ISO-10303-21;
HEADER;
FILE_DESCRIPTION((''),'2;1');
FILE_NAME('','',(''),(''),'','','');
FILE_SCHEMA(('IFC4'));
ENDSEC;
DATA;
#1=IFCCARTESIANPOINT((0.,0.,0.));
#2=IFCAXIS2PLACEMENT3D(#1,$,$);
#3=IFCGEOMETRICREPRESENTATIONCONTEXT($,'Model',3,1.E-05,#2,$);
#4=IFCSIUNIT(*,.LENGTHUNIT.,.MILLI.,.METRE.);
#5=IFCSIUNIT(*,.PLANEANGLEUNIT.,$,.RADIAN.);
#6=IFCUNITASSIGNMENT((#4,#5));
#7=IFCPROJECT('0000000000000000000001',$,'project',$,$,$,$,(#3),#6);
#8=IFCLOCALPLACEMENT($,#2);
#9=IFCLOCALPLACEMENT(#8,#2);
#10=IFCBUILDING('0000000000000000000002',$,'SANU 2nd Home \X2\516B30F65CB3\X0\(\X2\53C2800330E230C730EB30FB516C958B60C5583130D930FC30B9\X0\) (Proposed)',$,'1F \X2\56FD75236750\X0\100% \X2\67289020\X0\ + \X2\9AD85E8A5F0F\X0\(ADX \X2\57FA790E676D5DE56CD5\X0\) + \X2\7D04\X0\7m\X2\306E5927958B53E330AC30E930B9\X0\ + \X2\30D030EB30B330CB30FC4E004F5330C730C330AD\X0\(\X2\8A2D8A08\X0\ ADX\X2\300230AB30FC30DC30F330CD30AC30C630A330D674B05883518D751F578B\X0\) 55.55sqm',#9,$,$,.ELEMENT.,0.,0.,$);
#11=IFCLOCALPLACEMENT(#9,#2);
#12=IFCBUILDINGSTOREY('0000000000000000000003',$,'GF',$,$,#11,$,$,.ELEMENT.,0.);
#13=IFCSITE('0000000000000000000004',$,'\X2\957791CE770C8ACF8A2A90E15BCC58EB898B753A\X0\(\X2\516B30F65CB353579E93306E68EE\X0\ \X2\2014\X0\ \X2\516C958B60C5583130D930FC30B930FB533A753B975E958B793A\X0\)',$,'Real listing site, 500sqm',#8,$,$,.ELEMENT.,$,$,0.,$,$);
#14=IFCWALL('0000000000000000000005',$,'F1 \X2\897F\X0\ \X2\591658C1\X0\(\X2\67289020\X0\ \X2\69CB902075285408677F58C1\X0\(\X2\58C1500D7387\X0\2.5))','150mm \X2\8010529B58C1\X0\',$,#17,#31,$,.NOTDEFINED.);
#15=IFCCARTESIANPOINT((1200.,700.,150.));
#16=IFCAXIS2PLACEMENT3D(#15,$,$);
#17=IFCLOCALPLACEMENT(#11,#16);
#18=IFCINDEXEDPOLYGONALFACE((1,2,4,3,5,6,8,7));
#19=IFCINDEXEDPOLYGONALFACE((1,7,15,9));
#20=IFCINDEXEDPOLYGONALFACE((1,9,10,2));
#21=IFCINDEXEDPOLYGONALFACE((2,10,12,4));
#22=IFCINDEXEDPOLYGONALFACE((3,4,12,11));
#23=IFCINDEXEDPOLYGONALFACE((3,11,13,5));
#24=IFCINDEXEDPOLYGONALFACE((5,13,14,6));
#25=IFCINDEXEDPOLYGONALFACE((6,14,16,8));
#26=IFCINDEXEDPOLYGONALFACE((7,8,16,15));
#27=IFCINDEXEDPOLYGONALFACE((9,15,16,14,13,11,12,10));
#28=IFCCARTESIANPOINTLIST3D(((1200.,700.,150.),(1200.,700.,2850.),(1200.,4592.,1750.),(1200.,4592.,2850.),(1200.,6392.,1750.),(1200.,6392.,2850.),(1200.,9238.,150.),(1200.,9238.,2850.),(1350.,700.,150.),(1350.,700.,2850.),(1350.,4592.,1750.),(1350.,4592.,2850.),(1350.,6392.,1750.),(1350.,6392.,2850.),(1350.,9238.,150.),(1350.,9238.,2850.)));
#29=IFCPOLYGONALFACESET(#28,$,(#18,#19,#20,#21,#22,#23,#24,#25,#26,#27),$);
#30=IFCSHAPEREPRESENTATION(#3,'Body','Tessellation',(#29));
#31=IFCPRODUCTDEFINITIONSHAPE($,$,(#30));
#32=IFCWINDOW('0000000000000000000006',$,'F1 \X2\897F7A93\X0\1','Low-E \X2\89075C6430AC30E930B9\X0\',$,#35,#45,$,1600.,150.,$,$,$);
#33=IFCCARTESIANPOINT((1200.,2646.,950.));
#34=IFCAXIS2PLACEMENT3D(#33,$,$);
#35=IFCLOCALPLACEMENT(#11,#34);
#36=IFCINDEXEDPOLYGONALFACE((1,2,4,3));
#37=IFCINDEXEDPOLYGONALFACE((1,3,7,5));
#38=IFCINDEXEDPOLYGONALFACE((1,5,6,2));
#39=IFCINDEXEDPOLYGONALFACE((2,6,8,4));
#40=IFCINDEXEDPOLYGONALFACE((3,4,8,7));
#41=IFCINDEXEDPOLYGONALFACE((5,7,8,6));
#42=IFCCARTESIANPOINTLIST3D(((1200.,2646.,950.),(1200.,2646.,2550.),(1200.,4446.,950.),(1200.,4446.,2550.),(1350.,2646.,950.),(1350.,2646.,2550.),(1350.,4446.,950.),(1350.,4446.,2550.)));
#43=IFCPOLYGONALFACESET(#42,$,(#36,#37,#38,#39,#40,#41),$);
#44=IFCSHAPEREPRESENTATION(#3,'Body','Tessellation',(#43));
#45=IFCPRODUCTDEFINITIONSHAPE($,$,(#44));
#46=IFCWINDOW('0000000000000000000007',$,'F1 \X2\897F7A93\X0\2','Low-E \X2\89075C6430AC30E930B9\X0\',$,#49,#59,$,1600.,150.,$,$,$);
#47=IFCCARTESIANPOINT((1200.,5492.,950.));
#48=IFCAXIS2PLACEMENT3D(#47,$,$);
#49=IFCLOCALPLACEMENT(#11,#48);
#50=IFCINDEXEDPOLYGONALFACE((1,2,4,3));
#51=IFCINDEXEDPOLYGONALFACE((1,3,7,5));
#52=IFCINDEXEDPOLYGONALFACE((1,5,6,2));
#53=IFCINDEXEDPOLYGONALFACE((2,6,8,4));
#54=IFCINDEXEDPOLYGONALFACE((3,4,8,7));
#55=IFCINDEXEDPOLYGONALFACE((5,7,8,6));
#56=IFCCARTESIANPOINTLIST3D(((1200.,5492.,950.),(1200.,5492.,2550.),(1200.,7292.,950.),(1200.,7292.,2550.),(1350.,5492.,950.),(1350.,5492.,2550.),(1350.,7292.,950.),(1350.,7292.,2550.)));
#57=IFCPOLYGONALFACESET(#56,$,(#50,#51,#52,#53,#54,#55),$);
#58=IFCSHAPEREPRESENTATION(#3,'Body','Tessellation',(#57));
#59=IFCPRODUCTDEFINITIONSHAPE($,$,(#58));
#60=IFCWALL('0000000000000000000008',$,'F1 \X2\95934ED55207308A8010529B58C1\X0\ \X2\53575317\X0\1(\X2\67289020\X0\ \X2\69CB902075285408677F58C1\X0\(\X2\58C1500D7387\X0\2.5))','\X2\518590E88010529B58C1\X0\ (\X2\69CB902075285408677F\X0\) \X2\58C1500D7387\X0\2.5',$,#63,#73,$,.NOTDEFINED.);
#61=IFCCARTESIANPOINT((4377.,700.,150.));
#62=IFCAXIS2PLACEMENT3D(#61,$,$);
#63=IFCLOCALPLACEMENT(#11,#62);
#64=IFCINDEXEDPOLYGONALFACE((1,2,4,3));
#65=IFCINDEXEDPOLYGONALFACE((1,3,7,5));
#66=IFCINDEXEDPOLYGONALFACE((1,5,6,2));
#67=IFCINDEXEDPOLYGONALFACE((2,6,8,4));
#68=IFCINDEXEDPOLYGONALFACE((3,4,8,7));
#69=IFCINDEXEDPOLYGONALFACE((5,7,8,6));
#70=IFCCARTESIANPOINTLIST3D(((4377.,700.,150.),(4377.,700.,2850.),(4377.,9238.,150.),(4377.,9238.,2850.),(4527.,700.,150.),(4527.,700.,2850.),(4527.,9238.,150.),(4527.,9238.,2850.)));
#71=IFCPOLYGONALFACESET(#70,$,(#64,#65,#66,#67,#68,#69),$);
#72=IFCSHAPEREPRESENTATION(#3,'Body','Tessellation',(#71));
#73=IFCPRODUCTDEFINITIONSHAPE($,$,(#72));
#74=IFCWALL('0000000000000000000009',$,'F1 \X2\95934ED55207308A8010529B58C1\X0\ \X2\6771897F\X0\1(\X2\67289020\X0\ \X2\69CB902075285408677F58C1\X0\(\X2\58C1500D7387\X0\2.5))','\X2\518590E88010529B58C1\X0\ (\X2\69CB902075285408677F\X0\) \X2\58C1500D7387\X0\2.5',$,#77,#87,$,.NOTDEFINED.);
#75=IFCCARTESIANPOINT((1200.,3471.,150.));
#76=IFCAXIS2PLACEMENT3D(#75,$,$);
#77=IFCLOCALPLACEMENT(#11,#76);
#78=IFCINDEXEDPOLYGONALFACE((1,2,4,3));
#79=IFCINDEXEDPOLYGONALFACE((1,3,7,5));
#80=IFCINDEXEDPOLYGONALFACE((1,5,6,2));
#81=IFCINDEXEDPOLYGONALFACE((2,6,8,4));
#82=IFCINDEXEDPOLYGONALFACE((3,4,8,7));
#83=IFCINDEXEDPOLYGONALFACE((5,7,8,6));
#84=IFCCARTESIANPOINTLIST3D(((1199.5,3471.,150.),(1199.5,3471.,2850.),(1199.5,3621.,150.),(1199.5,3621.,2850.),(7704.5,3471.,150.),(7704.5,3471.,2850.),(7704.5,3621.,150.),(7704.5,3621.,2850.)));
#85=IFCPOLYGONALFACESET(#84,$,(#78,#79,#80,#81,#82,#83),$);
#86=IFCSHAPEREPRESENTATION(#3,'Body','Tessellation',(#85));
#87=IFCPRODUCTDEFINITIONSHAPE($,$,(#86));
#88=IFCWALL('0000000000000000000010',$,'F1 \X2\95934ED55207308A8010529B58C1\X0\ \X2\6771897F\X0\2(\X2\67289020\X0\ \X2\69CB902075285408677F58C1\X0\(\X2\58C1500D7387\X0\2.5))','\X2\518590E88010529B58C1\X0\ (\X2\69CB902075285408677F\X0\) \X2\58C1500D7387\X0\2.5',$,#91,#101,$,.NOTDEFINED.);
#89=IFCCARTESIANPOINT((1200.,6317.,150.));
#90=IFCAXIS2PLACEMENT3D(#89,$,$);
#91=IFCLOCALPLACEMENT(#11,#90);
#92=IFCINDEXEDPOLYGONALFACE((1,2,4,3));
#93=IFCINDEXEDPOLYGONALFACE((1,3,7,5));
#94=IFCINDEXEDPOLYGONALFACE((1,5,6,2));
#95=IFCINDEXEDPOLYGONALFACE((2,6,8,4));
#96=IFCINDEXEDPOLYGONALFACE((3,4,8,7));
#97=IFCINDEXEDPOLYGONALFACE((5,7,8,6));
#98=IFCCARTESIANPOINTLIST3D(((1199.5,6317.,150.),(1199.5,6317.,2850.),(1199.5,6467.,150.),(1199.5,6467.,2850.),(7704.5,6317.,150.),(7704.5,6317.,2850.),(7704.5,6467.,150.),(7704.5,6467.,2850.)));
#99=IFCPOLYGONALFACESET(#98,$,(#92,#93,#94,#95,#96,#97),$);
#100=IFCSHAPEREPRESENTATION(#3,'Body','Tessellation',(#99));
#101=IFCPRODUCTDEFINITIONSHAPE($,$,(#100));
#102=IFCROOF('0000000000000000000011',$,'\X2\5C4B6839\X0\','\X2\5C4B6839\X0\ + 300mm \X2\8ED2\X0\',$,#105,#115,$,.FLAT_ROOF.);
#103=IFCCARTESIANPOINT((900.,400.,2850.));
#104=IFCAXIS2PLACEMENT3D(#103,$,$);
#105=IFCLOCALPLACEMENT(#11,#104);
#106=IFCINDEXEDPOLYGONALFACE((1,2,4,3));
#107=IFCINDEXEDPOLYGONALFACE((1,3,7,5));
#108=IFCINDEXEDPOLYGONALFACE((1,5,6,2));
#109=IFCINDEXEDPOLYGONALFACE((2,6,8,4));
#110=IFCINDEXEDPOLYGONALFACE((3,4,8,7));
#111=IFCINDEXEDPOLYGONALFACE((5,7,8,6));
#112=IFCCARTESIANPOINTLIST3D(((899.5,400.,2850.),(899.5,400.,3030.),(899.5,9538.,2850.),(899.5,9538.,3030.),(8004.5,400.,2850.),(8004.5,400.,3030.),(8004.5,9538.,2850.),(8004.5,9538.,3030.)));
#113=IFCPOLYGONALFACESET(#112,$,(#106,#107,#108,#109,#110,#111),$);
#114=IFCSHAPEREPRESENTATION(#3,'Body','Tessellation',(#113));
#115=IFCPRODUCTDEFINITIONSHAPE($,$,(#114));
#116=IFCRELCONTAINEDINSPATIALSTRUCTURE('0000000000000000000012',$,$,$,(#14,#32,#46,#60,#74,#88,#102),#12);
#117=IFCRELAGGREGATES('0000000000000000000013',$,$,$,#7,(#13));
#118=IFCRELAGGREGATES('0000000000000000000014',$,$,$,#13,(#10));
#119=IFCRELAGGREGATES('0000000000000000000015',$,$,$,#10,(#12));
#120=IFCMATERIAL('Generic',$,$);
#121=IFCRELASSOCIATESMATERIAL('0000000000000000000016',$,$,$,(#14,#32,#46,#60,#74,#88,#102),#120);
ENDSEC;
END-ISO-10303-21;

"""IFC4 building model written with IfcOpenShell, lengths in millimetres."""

from ifc_helpers import new_model, si_unit, frame, frame_2d, origin, place, context, project, spatial, rectangle, extrude, material, element, fill, save


model = new_model("IFC4")

# Units and contexts
model_context = context("Model", 3, precision=1e-05, world=origin())
ifc_project = project(units=[si_unit("LENGTHUNIT", "METRE", prefix="MILLI"), si_unit("PLANEANGLEUNIT", "RADIAN")], contexts=[model_context])

# Site, building, storey
site_placement = place(None, origin())
site = spatial("IfcSite", under=ifc_project, at=site_placement, Name="長野県諏訪郡富士見町(八ヶ岳南麓の森 — 公開情報ベース・区画非開示)", ObjectType="Real listing site, 500sqm", CompositionType="ELEMENT", RefElevation=0.0)
building_placement = place(site_placement, origin())
building = spatial("IfcBuilding", under=site, at=building_placement, Name="SANU 2nd Home 八ヶ岳(参考モデル・公開情報ベース) (Proposed)", ObjectType="1F 国産材100% 木造 + 高床式(ADX 基礎杭工法) + 約7mの大開口ガラス + バルコニー一体デッキ(設計 ADX。カーボンネガティブ環境再生型) 55.55sqm", CompositionType="ELEMENT", ElevationOfRefHeight=0.0, ElevationOfTerrain=0.0)
storey_placement = place(building_placement, origin())
storey = spatial("IfcBuildingStorey", under=building, at=storey_placement, Name="GF", CompositionType="ELEMENT", Elevation=0.0)

# Shared definitions
ifc_material_1 = material(Name="Generic")

# Wall, openings, windows
wall_1_placement = place(storey_placement, frame((1200.0, 700.0, 150.0)))
wall_1 = element("IfcWall", 1, at=wall_1_placement, inside=storey, material=ifc_material_1, Name="F1 西 外壁(木造 構造用合板壁(壁倍率2.5))", Description="150mm 耐力壁", PredefinedType="NOTDEFINED", context=model_context, shape_type="SweptSolid", body=[
    extrude(rectangle(XDim=150.0, YDim=8538.0, at=frame_2d((75.0, 4269.0))), frame((1200.0, 700.0, 150.0)), (0.0, 0.0, 1.0), 2700.0),
])
opening_1_placement = place(storey_placement, frame((1200.0, 2646.0, 950.0)))
opening_1 = element("IfcOpeningElement", 2, at=opening_1_placement, cuts=wall_1, PredefinedType="NOTDEFINED", context=model_context, shape_type="SweptSolid", body=[
    extrude(rectangle(XDim=150.0, YDim=1800.0, at=frame_2d((75.0, 900.0))), frame((1200.0, 2646.0, 950.0)), (0.0, 0.0, 1.0), 1600.0),
])
opening_2_placement = place(storey_placement, frame((1200.0, 5492.0, 950.0)))
opening_2 = element("IfcOpeningElement", 3, at=opening_2_placement, cuts=wall_1, PredefinedType="NOTDEFINED", context=model_context, shape_type="SweptSolid", body=[
    extrude(rectangle(XDim=150.0, YDim=1800.0, at=frame_2d((75.0, 900.0))), frame((1200.0, 5492.0, 950.0)), (0.0, 0.0, 1.0), 1600.0),
])
window_1_placement = place(storey_placement, frame((1200.0, 2646.0, 950.0)))
window_1 = element("IfcWindow", 4, at=window_1_placement, inside=storey, material=ifc_material_1, Name="F1 西窓1", Description="Low-E 複層ガラス", OverallHeight=1600.0, OverallWidth=150.0, context=model_context, shape_type="SweptSolid", body=[
    extrude(rectangle(XDim=150.0, YDim=1800.0, at=frame_2d((75.0, 900.0))), frame((1200.0, 2646.0, 950.0)), (0.0, 0.0, 1.0), 1600.0),
])
fill(opening_1, window_1)
window_2_placement = place(storey_placement, frame((1200.0, 5492.0, 950.0)))
window_2 = element("IfcWindow", 5, at=window_2_placement, inside=storey, material=ifc_material_1, Name="F1 西窓2", Description="Low-E 複層ガラス", OverallHeight=1600.0, OverallWidth=150.0, context=model_context, shape_type="SweptSolid", body=[
    extrude(rectangle(XDim=150.0, YDim=1800.0, at=frame_2d((75.0, 900.0))), frame((1200.0, 5492.0, 950.0)), (0.0, 0.0, 1.0), 1600.0),
])
fill(opening_2, window_2)

# Walls
wall_2_placement = place(storey_placement, frame((4377.0, 700.0, 150.0)))
element("IfcWall", 6, at=wall_2_placement, inside=storey, material=ifc_material_1, Name="F1 間仕切り耐力壁 南北1(木造 構造用合板壁(壁倍率2.5))", Description="内部耐力壁 (構造用合板) 壁倍率2.5", PredefinedType="NOTDEFINED", context=model_context, shape_type="SweptSolid", body=[
    extrude(rectangle(XDim=150.0, YDim=8538.0, at=frame_2d((75.0, 4269.0))), frame((4377.0, 700.0, 150.0)), (0.0, 0.0, 1.0), 2700.0),
])
wall_3_placement = place(storey_placement, frame((1200.0, 3471.0, 150.0)))
element("IfcWall", 7, at=wall_3_placement, inside=storey, material=ifc_material_1, Name="F1 間仕切り耐力壁 東西1(木造 構造用合板壁(壁倍率2.5))", Description="内部耐力壁 (構造用合板) 壁倍率2.5", PredefinedType="NOTDEFINED", context=model_context, shape_type="SweptSolid", body=[
    extrude(rectangle(XDim=6505.0, YDim=150.0, at=frame_2d((3252.0, 75.0))), frame((1200.0, 3471.0, 150.0)), (0.0, 0.0, 1.0), 2700.0),
])
wall_4_placement = place(storey_placement, frame((1200.0, 6317.0, 150.0)))
element("IfcWall", 8, at=wall_4_placement, inside=storey, material=ifc_material_1, Name="F1 間仕切り耐力壁 東西2(木造 構造用合板壁(壁倍率2.5))", Description="内部耐力壁 (構造用合板) 壁倍率2.5", PredefinedType="NOTDEFINED", context=model_context, shape_type="SweptSolid", body=[
    extrude(rectangle(XDim=6505.0, YDim=150.0, at=frame_2d((3252.0, 75.0))), frame((1200.0, 6317.0, 150.0)), (0.0, 0.0, 1.0), 2700.0),
])

# Roof
roof_placement = place(storey_placement, frame((900.0, 400.0, 2850.0)))
element("IfcRoof", 9, at=roof_placement, inside=storey, material=ifc_material_1, Name="屋根", Description="屋根 + 300mm 軒", PredefinedType="FLAT_ROOF", context=model_context, shape_type="SweptSolid", body=[
    extrude(rectangle(XDim=7105.0, YDim=9138.0, at=frame_2d((3552.0, 4569.0))), frame((900.0, 400.0, 2850.0)), (0.0, 0.0, 1.0), 180.0),
])

save(model, "model.ifc")
